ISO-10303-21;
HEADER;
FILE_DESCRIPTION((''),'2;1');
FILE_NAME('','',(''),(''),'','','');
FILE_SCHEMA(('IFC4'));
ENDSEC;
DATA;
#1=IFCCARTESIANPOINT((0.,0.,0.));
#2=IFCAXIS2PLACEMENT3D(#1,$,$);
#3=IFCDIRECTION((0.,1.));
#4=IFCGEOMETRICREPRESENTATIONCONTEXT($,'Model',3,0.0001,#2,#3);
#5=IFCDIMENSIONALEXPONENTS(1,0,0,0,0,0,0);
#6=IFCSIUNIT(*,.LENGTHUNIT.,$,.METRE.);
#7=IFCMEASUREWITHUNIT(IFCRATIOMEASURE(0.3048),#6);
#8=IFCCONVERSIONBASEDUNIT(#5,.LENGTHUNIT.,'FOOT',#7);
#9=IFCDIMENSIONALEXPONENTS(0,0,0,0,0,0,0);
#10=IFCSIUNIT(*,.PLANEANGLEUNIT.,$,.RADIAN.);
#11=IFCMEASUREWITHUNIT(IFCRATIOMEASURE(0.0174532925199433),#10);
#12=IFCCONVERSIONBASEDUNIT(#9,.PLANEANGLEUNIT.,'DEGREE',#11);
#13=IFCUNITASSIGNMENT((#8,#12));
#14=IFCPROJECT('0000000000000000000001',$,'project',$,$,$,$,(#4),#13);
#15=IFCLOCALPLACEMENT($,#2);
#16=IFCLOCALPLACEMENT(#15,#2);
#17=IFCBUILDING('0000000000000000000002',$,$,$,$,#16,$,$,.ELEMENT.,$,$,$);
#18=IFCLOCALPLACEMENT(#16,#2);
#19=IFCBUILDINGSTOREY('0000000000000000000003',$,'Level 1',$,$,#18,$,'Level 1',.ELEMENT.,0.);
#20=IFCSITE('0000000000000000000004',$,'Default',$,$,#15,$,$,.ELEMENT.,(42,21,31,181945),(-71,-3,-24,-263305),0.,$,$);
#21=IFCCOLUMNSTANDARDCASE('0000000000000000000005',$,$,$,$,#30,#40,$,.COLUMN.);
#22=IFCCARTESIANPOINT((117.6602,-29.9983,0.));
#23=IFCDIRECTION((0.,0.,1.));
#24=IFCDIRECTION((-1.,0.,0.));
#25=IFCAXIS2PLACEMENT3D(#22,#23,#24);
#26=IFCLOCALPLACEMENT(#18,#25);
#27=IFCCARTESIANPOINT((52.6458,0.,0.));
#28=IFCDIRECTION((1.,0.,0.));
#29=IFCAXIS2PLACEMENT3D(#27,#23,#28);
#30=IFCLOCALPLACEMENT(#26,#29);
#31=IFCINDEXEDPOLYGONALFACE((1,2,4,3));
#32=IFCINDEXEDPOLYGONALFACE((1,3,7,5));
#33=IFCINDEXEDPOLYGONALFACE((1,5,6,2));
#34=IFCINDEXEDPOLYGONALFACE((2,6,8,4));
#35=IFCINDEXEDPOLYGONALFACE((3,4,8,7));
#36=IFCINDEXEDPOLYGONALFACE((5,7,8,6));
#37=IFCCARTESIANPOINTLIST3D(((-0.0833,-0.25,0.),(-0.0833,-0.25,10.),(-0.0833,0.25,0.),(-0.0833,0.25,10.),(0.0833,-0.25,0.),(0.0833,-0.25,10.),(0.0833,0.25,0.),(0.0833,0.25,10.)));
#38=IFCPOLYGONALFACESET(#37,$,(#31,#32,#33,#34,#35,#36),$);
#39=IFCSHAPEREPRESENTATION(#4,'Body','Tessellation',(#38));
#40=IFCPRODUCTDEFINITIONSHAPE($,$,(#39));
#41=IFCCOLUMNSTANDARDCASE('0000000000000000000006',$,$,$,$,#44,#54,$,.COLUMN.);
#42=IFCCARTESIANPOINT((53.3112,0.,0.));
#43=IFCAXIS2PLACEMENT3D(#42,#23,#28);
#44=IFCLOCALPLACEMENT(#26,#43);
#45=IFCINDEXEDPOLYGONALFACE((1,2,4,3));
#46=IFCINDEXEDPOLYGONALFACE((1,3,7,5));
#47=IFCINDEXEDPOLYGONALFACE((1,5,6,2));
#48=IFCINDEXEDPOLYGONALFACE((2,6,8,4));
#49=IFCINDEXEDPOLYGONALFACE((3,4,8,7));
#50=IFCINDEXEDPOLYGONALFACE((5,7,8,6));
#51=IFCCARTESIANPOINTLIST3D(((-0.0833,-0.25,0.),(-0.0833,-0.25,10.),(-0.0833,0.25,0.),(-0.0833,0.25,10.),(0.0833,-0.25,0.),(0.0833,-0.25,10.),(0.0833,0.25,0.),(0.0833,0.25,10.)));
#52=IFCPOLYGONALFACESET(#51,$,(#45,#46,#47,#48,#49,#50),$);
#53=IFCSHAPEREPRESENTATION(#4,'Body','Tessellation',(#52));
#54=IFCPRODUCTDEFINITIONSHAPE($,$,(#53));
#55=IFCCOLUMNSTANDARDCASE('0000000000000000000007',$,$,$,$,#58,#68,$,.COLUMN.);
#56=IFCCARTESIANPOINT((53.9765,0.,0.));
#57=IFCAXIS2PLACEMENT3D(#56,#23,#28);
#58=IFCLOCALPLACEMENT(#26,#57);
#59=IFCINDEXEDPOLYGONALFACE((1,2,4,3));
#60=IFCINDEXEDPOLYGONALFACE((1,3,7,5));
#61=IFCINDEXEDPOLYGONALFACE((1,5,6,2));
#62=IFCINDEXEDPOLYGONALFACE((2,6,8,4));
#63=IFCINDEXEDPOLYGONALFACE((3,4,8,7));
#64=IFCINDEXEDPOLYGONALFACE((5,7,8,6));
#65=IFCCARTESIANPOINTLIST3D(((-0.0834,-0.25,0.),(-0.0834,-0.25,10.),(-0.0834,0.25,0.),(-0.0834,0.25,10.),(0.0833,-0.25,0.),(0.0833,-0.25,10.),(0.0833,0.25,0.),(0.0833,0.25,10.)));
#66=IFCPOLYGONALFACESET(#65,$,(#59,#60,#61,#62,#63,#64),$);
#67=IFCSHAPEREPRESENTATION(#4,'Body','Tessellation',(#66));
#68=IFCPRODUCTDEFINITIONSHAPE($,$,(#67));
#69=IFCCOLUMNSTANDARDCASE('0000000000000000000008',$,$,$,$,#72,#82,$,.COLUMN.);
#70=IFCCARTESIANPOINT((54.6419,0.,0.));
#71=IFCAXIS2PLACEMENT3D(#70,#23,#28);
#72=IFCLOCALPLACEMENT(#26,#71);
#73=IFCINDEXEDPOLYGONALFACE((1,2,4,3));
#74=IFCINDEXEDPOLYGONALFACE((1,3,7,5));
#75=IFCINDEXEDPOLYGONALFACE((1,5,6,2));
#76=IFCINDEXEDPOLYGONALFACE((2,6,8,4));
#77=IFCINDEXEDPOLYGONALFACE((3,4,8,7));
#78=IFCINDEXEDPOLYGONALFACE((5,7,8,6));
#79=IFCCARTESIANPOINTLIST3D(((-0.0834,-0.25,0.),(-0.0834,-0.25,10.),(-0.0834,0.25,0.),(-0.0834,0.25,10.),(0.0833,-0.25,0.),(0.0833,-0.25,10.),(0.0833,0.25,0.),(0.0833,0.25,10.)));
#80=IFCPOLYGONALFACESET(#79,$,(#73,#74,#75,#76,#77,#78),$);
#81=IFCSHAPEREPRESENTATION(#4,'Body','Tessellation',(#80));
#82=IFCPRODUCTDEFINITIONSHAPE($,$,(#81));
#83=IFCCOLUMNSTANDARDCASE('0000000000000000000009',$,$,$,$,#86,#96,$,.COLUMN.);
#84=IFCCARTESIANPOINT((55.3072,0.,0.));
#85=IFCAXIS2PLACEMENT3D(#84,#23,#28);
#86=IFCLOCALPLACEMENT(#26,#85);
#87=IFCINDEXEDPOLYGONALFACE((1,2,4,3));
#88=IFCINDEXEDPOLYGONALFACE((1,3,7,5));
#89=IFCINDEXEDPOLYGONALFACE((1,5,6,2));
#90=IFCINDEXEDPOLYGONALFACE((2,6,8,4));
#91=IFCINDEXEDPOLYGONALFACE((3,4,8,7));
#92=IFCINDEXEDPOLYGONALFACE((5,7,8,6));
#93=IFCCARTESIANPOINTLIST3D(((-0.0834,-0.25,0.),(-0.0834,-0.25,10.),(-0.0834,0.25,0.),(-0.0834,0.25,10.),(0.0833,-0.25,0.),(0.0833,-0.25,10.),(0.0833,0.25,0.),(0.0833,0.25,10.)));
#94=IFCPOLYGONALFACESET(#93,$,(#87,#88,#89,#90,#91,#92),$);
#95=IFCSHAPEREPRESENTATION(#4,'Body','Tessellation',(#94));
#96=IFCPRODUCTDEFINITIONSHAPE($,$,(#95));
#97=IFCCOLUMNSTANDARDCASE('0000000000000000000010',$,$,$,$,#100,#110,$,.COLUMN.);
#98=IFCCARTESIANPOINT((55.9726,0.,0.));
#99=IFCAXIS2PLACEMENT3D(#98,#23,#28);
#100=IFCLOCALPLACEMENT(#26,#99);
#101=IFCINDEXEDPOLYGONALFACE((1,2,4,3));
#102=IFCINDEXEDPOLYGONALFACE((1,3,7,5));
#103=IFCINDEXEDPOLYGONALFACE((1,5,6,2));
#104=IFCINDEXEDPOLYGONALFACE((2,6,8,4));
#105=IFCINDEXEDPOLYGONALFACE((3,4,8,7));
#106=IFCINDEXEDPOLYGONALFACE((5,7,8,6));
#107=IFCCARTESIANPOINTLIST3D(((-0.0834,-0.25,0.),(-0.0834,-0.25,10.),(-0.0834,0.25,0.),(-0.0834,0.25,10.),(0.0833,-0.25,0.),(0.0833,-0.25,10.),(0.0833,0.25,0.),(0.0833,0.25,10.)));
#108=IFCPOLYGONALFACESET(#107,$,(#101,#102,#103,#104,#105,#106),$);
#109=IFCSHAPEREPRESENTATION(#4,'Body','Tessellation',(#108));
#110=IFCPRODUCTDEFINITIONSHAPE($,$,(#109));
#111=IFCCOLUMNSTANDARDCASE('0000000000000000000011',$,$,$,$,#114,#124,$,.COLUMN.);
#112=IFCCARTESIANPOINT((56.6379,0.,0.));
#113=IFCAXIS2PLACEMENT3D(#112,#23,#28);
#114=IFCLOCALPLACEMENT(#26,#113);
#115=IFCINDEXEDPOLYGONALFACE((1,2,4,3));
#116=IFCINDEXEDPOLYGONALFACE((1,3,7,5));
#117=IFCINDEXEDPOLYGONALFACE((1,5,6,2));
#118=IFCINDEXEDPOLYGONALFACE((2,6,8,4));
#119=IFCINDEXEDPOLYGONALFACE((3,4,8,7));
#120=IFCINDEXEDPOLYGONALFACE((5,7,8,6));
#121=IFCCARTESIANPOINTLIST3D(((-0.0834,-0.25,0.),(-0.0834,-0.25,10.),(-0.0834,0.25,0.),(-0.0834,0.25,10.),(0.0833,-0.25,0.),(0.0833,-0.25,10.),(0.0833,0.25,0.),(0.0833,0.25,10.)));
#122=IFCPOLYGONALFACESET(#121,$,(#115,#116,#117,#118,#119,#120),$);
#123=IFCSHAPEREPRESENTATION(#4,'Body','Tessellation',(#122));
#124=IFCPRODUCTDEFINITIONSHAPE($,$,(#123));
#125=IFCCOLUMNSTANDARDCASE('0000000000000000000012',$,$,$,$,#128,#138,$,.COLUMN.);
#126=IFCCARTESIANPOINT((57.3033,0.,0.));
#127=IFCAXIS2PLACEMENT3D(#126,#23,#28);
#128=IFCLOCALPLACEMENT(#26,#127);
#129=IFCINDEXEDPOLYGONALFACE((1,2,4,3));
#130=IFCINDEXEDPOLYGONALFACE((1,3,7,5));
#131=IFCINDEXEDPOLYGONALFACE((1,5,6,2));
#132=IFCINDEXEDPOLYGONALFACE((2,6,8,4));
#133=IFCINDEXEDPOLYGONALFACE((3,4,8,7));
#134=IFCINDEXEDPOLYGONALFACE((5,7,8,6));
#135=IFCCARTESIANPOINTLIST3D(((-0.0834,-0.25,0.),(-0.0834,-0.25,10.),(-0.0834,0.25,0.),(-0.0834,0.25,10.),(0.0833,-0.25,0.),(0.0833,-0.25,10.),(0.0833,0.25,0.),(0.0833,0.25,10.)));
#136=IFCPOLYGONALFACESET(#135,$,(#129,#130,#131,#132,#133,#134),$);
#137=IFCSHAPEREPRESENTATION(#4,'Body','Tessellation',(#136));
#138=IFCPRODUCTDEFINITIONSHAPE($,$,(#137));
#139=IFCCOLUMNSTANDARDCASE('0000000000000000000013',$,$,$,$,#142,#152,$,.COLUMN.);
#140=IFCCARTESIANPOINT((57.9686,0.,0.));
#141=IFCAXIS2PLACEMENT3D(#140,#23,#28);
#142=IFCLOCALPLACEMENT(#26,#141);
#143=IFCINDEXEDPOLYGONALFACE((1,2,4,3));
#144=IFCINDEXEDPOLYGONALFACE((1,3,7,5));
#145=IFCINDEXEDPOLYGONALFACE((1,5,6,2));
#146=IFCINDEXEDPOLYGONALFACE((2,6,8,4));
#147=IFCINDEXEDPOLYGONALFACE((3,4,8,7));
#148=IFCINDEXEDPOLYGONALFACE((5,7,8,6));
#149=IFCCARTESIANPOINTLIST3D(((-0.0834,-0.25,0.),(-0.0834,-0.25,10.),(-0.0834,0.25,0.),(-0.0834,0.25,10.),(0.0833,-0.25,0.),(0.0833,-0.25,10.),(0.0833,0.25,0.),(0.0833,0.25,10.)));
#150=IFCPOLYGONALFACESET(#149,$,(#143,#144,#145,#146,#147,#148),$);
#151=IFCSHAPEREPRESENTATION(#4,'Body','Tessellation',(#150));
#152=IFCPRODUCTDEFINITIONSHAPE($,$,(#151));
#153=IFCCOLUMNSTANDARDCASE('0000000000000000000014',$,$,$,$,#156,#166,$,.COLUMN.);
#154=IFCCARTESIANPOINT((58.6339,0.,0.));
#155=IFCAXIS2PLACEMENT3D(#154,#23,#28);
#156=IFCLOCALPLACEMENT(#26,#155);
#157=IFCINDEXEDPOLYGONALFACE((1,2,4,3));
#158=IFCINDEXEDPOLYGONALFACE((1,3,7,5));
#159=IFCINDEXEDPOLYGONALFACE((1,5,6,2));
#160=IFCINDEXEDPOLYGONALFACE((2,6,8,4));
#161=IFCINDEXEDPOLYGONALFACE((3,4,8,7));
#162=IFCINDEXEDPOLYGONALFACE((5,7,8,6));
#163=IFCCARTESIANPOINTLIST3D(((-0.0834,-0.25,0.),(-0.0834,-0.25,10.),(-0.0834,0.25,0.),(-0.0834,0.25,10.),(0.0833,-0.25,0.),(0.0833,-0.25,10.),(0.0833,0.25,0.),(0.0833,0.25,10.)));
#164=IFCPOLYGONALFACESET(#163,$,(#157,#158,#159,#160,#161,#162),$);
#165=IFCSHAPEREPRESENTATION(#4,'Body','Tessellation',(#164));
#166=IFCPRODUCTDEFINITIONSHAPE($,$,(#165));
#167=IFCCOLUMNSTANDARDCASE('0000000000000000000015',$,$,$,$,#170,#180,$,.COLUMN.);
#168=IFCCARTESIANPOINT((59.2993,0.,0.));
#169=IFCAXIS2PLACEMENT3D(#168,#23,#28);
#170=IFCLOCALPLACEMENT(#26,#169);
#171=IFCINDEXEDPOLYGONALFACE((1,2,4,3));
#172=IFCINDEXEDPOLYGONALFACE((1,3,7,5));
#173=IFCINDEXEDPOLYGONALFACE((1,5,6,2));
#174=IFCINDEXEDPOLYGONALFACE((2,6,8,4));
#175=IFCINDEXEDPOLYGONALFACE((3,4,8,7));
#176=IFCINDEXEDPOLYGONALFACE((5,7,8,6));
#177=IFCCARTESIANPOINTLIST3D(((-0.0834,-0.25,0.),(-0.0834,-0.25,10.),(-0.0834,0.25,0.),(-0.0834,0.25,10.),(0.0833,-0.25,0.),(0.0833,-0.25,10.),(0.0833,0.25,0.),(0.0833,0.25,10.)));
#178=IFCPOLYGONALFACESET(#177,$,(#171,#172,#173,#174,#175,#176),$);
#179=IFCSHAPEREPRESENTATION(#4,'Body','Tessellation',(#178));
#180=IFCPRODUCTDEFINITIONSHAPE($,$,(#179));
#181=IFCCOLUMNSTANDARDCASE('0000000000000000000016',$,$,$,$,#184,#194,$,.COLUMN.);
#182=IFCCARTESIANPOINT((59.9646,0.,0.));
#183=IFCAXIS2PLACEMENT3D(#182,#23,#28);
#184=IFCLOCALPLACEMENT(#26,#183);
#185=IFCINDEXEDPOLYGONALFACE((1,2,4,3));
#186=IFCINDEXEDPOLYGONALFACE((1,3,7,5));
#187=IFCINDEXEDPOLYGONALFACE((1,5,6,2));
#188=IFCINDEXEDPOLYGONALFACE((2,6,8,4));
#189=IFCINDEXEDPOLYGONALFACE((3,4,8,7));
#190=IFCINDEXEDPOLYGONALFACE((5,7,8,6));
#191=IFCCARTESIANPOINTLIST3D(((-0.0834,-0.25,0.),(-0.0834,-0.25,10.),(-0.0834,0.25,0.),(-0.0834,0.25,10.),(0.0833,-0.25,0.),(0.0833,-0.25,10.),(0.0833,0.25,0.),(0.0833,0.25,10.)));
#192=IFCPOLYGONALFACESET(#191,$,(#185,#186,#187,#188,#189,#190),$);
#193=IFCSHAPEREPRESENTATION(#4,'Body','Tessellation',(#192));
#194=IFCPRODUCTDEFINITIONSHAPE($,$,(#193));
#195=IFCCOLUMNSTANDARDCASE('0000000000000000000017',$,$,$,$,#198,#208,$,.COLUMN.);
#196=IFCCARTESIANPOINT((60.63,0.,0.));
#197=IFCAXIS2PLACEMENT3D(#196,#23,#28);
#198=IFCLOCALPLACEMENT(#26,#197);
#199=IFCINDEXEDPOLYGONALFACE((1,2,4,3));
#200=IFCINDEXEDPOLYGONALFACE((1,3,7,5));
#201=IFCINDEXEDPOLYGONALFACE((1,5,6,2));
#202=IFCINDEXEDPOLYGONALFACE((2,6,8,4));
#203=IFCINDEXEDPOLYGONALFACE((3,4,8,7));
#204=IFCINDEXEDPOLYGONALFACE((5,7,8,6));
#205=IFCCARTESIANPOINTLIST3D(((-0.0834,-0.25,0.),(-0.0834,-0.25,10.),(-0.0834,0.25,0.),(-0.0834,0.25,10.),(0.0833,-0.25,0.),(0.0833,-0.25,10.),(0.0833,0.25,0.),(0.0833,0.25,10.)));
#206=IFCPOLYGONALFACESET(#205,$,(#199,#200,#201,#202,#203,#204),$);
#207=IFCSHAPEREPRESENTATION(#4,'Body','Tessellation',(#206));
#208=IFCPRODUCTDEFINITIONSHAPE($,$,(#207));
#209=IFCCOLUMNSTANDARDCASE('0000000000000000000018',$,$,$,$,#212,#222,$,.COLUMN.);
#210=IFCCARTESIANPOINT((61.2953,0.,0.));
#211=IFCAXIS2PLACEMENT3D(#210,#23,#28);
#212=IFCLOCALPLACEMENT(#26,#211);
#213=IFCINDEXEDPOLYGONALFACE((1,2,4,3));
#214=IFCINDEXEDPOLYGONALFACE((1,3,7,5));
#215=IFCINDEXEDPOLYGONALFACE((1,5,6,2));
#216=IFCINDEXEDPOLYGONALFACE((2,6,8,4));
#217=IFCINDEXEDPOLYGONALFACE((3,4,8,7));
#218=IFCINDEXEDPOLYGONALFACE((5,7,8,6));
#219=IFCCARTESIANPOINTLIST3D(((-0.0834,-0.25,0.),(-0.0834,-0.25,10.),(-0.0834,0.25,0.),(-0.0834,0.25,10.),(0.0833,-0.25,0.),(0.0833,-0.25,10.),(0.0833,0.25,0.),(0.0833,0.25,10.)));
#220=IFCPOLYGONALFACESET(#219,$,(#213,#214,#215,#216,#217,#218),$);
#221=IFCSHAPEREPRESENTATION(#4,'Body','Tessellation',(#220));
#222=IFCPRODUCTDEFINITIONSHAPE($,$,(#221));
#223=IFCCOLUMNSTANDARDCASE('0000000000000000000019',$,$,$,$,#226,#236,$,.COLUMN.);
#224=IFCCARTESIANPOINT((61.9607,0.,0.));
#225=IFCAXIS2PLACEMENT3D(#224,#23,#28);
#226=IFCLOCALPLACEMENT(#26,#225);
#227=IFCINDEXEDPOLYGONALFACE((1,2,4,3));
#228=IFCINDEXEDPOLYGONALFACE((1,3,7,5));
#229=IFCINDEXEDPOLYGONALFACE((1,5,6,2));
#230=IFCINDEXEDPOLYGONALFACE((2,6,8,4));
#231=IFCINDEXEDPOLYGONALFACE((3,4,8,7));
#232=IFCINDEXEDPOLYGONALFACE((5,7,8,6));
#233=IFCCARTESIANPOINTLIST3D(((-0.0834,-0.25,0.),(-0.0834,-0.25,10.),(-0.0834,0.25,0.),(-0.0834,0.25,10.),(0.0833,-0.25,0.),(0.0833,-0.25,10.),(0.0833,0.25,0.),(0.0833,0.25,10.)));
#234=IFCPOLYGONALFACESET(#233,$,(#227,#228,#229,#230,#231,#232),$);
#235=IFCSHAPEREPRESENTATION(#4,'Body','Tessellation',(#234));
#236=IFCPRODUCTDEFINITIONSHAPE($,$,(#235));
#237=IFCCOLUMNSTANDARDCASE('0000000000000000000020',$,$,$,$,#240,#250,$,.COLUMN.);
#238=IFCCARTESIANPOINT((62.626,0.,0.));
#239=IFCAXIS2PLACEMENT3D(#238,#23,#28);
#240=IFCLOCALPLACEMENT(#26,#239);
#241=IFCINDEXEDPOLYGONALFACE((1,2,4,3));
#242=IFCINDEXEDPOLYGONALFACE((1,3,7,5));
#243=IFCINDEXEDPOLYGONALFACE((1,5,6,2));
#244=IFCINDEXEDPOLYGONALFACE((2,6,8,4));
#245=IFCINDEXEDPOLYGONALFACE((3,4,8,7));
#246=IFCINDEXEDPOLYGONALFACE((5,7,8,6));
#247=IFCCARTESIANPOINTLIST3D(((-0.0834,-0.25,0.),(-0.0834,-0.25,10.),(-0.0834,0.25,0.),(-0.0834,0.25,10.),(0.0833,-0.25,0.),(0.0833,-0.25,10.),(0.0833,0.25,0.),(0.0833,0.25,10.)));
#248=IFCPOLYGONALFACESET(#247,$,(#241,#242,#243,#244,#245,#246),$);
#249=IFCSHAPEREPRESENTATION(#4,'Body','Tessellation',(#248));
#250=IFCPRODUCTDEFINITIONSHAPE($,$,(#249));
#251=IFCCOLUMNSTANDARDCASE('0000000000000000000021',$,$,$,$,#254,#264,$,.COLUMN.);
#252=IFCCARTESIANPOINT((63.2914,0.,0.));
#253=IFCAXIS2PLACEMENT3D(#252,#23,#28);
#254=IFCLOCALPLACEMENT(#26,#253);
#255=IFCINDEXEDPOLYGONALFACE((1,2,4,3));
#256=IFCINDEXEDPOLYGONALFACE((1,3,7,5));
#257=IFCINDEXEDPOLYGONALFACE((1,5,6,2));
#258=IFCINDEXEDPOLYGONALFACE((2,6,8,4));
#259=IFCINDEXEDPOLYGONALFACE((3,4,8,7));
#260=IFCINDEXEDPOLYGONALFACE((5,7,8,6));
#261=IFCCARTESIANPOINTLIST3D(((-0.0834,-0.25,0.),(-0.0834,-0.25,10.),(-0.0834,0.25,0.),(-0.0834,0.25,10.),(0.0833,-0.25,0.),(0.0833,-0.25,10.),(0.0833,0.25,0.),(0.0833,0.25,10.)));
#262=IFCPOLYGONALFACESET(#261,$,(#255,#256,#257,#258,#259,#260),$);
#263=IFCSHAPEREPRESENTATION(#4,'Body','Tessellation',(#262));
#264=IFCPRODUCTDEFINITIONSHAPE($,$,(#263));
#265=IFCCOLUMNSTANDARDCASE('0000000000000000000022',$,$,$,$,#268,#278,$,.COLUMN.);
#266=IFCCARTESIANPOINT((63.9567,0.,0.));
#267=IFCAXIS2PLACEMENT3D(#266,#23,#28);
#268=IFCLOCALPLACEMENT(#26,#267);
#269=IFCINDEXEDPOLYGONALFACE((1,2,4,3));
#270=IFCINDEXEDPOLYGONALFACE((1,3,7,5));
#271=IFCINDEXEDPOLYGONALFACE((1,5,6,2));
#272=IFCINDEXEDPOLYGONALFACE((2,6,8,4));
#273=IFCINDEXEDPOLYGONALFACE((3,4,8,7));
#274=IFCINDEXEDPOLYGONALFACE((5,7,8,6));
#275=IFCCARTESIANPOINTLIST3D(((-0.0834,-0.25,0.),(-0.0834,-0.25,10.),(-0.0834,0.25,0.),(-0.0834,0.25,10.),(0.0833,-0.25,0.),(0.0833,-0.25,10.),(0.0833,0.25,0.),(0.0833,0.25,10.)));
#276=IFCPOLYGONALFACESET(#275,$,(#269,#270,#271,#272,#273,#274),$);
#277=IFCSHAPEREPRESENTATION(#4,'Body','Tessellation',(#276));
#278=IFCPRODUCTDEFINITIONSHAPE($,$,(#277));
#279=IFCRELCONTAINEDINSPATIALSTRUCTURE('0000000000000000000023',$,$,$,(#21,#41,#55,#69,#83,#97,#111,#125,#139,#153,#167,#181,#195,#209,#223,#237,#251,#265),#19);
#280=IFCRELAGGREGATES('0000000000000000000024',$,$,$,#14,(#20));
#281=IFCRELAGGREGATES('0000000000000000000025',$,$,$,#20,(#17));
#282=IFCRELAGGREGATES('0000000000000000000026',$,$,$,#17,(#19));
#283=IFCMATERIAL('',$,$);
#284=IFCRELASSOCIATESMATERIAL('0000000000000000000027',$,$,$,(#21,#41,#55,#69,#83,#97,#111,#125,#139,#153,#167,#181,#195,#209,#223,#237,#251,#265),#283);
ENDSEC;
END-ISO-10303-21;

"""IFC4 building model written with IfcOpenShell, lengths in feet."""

from ifc_helpers import new_model, entity, si_unit, converted_unit, direction, frame, origin, place, context, project, spatial, rectangle, extrude, material, element, save


model = new_model("IFC4")

# Units and contexts
model_context = context("Model", 3, precision=0.0001, world=origin(), true_north=direction((0.0, 1.0)))
ifc_project = project(units=[converted_unit("LENGTHUNIT", "FOOT", entity("IfcRatioMeasure", 0.3048), si_unit("LENGTHUNIT", "METRE"), dimensions=[1, 0, 0, 0, 0, 0, 0]), converted_unit("PLANEANGLEUNIT", "DEGREE", entity("IfcRatioMeasure", 0.0174532925199433), si_unit("PLANEANGLEUNIT", "RADIAN"), dimensions=[0, 0, 0, 0, 0, 0, 0])], contexts=[model_context])

# Site, building, storey
site_placement = place(None, origin())
site = spatial("IfcSite", under=ifc_project, at=site_placement, Name="Default", CompositionType="ELEMENT", RefLatitude=(42, 21, 31, 181945), RefLongitude=(-71, -3, -24, -263305), RefElevation=0.0)
building_placement = place(site_placement, origin())
building = spatial("IfcBuilding", under=site, at=building_placement, CompositionType="ELEMENT")
storey_placement = place(building_placement, origin())
storey = spatial("IfcBuildingStorey", under=building, at=storey_placement, Name="Level 1", LongName="Level 1", CompositionType="ELEMENT", Elevation=0.0)

# Columns
ifc_material = material(Name="")
placement = place(storey_placement, frame((117.6602, -29.9983, 0.0), z_axis=(0.0, 0.0, 1.0), x_axis=(-1.0, 0.0, 0.0)))
for number, where, z_axis, x_axis in (
    (1, (52.6458, 0.0, 0.0), (0.0, 0.0, 1.0), (1.0, 0.0, 0.0)),
    (2, (53.3112, 0.0, 0.0), (0.0, 0.0, 1.0), (1.0, 0.0, 0.0)),
    (3, (53.9765, 0.0, 0.0), (0.0, 0.0, 1.0), (1.0, 0.0, 0.0)),
    (4, (54.6419, 0.0, 0.0), (0.0, 0.0, 1.0), (1.0, 0.0, 0.0)),
    (5, (55.3072, 0.0, 0.0), (0.0, 0.0, 1.0), (1.0, 0.0, 0.0)),
    (6, (55.9726, 0.0, 0.0), (0.0, 0.0, 1.0), (1.0, 0.0, 0.0)),
    (7, (56.6379, 0.0, 0.0), (0.0, 0.0, 1.0), (1.0, 0.0, 0.0)),
    (8, (57.3033, 0.0, 0.0), (0.0, 0.0, 1.0), (1.0, 0.0, 0.0)),
    (9, (57.9686, 0.0, 0.0), (0.0, 0.0, 1.0), (1.0, 0.0, 0.0)),
    (10, (58.6339, 0.0, 0.0), (0.0, 0.0, 1.0), (1.0, 0.0, 0.0)),
    (11, (59.2993, 0.0, 0.0), (0.0, 0.0, 1.0), (1.0, 0.0, 0.0)),
    (12, (59.9646, 0.0, 0.0), (0.0, 0.0, 1.0), (1.0, 0.0, 0.0)),
    (13, (60.63, 0.0, 0.0), (0.0, 0.0, 1.0), (1.0, 0.0, 0.0)),
    (14, (61.2953, 0.0, 0.0), (0.0, 0.0, 1.0), (1.0, 0.0, 0.0)),
    (15, (61.9607, 0.0, 0.0), (0.0, 0.0, 1.0), (1.0, 0.0, 0.0)),
    (16, (62.626, 0.0, 0.0), (0.0, 0.0, 1.0), (1.0, 0.0, 0.0)),
    (17, (63.2914, 0.0, 0.0), (0.0, 0.0, 1.0), (1.0, 0.0, 0.0)),
    (18, (63.9567, 0.0, 0.0), (0.0, 0.0, 1.0), (1.0, 0.0, 0.0)),
):
    element("IfcColumnStandardCase", number, at=place(placement, frame(where, z_axis=z_axis, x_axis=x_axis)), inside=storey, material=ifc_material, PredefinedType="COLUMN", context=model_context, shape_type="SweptSolid", body=[
        extrude(rectangle(XDim=0.1667, YDim=0.5), origin(), (0.0, 0.0, 1.0), 10.0),
    ])

save(model, "model.ifc")
